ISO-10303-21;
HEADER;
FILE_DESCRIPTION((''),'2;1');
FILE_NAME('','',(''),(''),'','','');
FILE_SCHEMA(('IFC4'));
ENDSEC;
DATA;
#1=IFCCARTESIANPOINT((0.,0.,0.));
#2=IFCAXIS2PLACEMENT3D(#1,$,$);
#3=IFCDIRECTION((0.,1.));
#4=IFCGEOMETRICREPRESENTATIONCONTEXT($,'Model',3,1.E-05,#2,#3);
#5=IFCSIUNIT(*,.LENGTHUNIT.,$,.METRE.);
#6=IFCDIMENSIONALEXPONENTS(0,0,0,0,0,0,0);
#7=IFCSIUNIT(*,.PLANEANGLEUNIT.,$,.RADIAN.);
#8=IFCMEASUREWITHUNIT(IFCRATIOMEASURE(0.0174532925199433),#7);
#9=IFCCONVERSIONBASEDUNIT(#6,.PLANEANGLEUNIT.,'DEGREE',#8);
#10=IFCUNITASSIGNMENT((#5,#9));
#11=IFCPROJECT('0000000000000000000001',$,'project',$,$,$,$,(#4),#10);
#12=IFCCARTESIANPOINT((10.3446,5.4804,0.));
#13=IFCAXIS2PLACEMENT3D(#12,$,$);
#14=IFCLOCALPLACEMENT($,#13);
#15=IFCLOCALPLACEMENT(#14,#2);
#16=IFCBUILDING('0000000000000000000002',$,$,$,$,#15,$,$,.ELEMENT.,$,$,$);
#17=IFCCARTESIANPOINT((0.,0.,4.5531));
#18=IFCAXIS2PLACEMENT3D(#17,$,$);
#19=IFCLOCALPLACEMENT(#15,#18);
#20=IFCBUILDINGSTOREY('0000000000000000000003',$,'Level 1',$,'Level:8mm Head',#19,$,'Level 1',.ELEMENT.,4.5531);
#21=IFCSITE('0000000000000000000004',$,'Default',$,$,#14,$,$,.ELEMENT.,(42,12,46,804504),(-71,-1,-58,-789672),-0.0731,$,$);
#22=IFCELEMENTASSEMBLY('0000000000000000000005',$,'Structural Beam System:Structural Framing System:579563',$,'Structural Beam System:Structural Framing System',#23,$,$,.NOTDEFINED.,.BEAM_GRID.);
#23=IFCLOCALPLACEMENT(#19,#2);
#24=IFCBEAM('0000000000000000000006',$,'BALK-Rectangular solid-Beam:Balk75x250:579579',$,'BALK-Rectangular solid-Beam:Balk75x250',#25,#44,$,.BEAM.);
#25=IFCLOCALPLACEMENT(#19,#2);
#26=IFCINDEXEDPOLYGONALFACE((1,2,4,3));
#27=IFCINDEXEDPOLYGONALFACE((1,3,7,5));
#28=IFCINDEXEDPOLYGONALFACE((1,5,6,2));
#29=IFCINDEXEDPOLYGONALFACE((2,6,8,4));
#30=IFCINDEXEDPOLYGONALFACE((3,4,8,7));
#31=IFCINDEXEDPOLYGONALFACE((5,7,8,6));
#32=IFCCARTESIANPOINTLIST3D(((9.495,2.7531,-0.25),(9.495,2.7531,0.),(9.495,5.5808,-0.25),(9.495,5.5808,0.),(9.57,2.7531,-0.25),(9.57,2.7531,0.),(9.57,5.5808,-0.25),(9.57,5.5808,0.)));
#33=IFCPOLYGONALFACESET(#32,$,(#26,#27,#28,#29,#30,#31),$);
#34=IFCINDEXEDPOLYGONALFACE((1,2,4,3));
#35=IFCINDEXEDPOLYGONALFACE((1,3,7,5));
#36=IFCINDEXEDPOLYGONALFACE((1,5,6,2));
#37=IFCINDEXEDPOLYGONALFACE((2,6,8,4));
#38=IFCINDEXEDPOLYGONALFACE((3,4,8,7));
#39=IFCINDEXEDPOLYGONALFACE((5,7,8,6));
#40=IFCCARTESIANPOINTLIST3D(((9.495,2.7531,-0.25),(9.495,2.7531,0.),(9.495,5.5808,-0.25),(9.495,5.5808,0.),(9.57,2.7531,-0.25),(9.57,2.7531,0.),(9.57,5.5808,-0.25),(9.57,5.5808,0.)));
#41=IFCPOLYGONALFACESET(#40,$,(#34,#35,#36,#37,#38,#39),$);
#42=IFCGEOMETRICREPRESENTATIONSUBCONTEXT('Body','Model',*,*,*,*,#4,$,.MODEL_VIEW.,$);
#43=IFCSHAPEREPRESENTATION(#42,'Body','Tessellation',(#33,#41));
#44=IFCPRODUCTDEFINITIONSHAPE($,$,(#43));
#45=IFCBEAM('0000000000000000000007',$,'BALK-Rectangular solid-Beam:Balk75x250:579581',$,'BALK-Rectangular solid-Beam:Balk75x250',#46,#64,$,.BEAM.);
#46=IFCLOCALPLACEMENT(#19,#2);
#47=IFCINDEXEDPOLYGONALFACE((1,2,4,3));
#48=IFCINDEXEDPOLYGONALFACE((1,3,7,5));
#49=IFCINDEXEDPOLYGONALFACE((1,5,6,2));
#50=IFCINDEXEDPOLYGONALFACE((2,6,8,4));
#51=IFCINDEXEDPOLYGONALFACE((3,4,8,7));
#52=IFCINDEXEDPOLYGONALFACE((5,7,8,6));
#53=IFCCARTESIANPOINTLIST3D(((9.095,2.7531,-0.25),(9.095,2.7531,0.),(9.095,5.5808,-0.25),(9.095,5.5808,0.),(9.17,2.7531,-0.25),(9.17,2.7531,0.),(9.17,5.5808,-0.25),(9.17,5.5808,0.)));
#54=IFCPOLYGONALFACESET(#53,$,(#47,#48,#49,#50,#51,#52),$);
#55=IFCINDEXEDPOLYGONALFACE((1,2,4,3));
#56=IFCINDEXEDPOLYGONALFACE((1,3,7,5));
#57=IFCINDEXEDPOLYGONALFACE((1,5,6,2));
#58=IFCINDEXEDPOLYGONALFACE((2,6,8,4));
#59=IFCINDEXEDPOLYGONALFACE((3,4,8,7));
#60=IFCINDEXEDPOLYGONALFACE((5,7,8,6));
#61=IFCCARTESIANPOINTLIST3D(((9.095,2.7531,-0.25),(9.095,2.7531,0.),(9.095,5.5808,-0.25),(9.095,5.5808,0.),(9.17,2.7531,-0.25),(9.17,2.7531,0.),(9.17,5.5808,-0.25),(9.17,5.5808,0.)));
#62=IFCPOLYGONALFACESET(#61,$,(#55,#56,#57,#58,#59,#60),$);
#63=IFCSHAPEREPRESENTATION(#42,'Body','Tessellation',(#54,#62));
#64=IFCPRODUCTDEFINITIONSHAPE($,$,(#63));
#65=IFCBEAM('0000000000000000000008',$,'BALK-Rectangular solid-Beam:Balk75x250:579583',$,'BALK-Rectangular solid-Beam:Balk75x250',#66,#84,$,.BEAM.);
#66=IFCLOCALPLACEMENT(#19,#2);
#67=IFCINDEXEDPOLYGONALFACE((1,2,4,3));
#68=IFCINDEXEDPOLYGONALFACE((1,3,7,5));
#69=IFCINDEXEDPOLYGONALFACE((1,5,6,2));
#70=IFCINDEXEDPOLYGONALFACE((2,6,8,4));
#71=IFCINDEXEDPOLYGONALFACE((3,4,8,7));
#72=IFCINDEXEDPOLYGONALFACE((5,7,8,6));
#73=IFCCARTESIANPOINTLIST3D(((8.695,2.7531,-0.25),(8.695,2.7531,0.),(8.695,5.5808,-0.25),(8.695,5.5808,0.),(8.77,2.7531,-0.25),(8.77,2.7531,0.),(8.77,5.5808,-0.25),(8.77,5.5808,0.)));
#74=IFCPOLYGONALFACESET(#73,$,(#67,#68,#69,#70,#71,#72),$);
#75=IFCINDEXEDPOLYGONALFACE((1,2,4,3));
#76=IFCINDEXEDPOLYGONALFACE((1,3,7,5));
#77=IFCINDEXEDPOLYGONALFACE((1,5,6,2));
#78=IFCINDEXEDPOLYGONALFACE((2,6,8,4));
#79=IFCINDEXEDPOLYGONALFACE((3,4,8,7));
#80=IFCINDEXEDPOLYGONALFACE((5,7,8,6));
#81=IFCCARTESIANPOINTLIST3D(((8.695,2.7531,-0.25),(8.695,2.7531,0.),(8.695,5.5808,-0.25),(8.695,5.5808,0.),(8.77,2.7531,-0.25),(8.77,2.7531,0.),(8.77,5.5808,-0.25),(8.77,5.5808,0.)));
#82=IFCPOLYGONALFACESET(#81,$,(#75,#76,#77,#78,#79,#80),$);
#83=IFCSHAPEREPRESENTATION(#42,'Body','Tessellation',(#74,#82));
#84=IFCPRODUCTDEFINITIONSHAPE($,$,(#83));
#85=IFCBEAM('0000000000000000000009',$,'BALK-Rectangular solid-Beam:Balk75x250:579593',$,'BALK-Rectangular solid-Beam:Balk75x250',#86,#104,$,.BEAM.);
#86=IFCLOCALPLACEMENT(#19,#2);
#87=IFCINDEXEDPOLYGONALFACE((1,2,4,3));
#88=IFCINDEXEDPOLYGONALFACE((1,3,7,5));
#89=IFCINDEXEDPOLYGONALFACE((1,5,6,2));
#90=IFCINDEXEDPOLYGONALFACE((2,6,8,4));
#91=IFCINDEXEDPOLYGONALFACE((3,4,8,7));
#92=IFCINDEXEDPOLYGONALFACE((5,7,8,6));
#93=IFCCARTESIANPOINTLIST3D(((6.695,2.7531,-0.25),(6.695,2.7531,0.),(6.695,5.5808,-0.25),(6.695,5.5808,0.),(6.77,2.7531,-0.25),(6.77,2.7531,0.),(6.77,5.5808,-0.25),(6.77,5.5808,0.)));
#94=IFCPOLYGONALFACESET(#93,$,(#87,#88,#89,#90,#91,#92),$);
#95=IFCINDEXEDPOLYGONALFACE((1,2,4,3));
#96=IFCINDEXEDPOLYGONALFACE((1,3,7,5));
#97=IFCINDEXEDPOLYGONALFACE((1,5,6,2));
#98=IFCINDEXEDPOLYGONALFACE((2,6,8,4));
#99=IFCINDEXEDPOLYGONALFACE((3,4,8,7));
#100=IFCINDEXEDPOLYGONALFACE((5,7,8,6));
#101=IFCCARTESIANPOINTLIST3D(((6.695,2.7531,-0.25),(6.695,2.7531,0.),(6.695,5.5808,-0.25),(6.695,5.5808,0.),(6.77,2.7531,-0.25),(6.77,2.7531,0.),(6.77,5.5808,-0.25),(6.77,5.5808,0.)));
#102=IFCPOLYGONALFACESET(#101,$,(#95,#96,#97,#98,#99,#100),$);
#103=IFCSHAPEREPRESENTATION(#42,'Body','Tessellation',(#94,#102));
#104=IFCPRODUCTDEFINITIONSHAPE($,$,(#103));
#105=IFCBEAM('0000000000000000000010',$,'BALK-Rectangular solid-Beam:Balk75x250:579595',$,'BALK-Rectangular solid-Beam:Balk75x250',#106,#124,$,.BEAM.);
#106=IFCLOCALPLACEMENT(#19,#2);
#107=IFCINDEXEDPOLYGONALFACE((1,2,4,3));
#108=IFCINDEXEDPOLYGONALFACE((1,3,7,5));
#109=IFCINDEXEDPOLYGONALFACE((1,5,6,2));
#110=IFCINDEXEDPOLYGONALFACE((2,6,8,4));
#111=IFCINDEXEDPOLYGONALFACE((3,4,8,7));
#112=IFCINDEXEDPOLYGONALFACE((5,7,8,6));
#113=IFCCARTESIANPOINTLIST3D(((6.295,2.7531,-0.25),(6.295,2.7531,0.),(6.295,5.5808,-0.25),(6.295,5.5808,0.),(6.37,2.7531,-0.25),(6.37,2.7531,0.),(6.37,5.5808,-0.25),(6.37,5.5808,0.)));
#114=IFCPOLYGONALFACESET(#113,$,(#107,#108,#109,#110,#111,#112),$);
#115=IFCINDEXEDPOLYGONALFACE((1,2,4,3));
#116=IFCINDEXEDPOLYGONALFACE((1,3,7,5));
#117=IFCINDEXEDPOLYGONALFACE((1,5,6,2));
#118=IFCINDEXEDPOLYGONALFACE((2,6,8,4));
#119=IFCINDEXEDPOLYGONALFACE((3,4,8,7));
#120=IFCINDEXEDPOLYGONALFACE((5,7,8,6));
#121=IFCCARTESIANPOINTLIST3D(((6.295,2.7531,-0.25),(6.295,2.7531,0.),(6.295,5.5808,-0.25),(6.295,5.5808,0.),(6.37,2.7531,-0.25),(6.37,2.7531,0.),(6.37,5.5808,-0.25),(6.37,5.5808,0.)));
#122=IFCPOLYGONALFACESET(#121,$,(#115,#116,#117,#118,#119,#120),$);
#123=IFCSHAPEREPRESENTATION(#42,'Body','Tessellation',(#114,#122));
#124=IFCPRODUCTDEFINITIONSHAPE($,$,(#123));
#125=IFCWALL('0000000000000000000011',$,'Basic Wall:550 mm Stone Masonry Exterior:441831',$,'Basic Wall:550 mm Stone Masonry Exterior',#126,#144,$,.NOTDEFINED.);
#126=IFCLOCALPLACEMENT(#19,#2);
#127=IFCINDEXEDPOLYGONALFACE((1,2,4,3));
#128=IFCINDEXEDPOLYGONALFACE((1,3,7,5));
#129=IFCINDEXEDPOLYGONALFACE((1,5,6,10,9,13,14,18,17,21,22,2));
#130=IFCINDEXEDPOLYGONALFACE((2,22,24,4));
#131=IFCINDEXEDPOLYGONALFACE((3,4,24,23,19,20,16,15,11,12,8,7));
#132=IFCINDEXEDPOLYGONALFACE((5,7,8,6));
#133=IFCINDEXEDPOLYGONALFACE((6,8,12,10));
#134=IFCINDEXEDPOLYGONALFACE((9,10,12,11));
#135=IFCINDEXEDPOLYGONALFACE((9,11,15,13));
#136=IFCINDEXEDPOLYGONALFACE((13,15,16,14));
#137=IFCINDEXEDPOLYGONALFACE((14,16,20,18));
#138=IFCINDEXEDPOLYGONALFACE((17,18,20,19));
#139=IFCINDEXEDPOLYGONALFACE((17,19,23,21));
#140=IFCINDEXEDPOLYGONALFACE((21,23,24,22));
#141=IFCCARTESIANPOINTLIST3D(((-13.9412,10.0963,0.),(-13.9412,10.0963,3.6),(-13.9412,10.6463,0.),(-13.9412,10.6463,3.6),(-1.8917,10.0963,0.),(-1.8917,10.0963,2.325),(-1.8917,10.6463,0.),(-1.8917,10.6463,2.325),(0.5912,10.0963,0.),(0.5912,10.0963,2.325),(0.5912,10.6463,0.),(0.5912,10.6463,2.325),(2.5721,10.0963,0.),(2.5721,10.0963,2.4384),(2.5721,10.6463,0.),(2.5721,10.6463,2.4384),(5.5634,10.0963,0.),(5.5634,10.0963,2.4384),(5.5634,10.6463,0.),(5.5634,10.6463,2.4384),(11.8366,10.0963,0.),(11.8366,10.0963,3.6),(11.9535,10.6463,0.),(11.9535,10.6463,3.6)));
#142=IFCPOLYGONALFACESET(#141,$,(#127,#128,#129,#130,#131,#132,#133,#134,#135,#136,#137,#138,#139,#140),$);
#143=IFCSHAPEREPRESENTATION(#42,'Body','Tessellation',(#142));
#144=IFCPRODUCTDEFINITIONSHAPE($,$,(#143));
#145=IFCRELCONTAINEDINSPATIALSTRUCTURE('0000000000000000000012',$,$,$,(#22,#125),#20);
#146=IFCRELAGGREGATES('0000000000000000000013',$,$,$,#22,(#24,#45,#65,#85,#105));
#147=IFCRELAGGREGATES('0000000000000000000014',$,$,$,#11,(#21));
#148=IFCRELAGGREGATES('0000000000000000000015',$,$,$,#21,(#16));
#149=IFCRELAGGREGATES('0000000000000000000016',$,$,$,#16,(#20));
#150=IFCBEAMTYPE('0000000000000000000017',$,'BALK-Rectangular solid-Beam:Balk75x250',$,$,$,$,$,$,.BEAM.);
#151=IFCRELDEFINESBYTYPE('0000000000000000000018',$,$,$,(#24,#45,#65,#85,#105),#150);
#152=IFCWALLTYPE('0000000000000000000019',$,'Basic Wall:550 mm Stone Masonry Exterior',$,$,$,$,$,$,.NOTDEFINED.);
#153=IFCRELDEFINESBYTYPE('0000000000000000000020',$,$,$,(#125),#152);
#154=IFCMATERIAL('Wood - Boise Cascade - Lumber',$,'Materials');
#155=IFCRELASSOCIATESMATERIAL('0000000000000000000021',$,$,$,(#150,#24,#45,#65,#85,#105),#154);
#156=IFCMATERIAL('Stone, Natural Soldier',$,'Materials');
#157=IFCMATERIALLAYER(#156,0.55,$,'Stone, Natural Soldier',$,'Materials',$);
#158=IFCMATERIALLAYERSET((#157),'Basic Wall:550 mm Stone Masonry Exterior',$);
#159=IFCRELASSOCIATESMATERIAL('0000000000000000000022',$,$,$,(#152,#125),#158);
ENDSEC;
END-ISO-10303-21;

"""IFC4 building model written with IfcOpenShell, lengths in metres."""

from ifc_helpers import new_model, entity, si_unit, converted_unit, direction, frame, frame_2d, origin, origin_2d_with_axis, place, context, subcontext, project, spatial, polyline, rectangle, outline, extrude, source, transform, mapped, material, layer, layer_set, layer_usage, material_profile, profile_set, profile_usage, type_object, type_shapes, element, aggregate, save


model = new_model("IFC4")

# Units and contexts
model_context = context("Model", 3, precision=1e-05, world=origin(), true_north=direction((0.0, 1.0)))
body_context = subcontext(model_context, "Body", "Model", "MODEL_VIEW")
ifc_project = project(units=[si_unit("LENGTHUNIT", "METRE"), converted_unit("PLANEANGLEUNIT", "DEGREE", entity("IfcRatioMeasure", 0.0174532925199433), si_unit("PLANEANGLEUNIT", "RADIAN"), dimensions=[0, 0, 0, 0, 0, 0, 0])], contexts=[model_context])

# Site, building, storey
site_placement = place(None, frame((10.3446, 5.4804, 0.0)))
site = spatial("IfcSite", under=ifc_project, at=site_placement, Name="Default", CompositionType="ELEMENT", RefLatitude=(42, 12, 46, 804504), RefLongitude=(-71, -1, -58, -789672), RefElevation=-0.0731)
building_placement = place(site_placement, origin())
building = spatial("IfcBuilding", under=site, at=building_placement, CompositionType="ELEMENT")
storey_placement = place(building_placement, frame((0.0, 0.0, 4.5531)))
storey = spatial("IfcBuildingStorey", under=building, at=storey_placement, Name="Level 1", ObjectType="Level:8mm Head", LongName="Level 1", CompositionType="ELEMENT", Elevation=4.5531)

# Element assembly, beams
ifc_material_1 = material(Name="Wood - Boise Cascade - Lumber", Category="Materials")
ifc_material_profile = material_profile(ifc_material_1, rectangle(XDim=0.25, YDim=0.075, at=frame_2d((0.0, 0.0), x_axis=(1.0, 0.0))), Name="Balk75x250")
ifc_profile_set = profile_set([ifc_material_profile], Name="Balk75x250")
assembly_1_placement = place(storey_placement, origin())
assembly_1 = element("IfcElementAssembly", 1, at=assembly_1_placement, inside=storey, Name="Structural Beam System:Structural Framing System:579563", ObjectType="Structural Beam System:Structural Framing System", AssemblyPlace="NOTDEFINED", PredefinedType="BEAM_GRID")
ifc_profile_usage_1 = profile_usage(ifc_profile_set, cardinal=8)
beam_type_1 = type_object("IfcBeamType", Name="BALK-Rectangular solid-Beam:Balk75x250", PredefinedType="BEAM", material=ifc_profile_set)
shared_shape_1 = source(origin(), body_context, "Body", "SweptSolid", [
    extrude(rectangle(XDim=0.25, YDim=0.075, at=origin_2d_with_axis()), frame((-1.4138, 0.0, 0.0), z_axis=(1.0, 0.0, 0.0), x_axis=(0.0, 0.0, -1.0)), (0.0, 0.0, 1.0), 2.8276),
    extrude(rectangle(XDim=0.25, YDim=0.075, at=origin_2d_with_axis()), frame((-1.4138, 0.0, 0.0), z_axis=(1.0, 0.0, 0.0), x_axis=(0.0, 0.0, -1.0)), (0.0, 0.0, 1.0), 2.8276),
])
type_shapes(beam_type_1, [shared_shape_1])
beam_1_placement = place(assembly_1_placement, frame((9.5325, 4.167, -0.125), z_axis=(0.0, 0.0, 1.0), x_axis=(0.0, -1.0, 0.0)))
beam_1 = element("IfcBeam", 2, at=beam_1_placement, type_object=beam_type_1, material=ifc_profile_usage_1, Name="BALK-Rectangular solid-Beam:Balk75x250:579579", ObjectType="BALK-Rectangular solid-Beam:Balk75x250", PredefinedType="BEAM", context=body_context, shape_type="MappedRepresentation", body=[
    mapped(shared_shape_1, transform((0.0, 0.0, 0.0), scale=1.0)),
])
ifc_profile_usage_2 = profile_usage(ifc_profile_set, cardinal=8)
beam_2_placement = place(assembly_1_placement, frame((9.1325, 4.167, -0.125), z_axis=(0.0, 0.0, 1.0), x_axis=(0.0, -1.0, 0.0)))
beam_2 = element("IfcBeam", 3, at=beam_2_placement, type_object=beam_type_1, material=ifc_profile_usage_2, Name="BALK-Rectangular solid-Beam:Balk75x250:579581", ObjectType="BALK-Rectangular solid-Beam:Balk75x250", PredefinedType="BEAM", context=body_context, shape_type="MappedRepresentation", body=[
    mapped(shared_shape_1, transform((0.0, 0.0, 0.0), scale=1.0)),
])
ifc_profile_usage_3 = profile_usage(ifc_profile_set, cardinal=8)
beam_3_placement = place(assembly_1_placement, frame((8.7325, 4.167, -0.125), z_axis=(0.0, 0.0, 1.0), x_axis=(0.0, -1.0, 0.0)))
beam_3 = element("IfcBeam", 4, at=beam_3_placement, type_object=beam_type_1, material=ifc_profile_usage_3, Name="BALK-Rectangular solid-Beam:Balk75x250:579583", ObjectType="BALK-Rectangular solid-Beam:Balk75x250", PredefinedType="BEAM", context=body_context, shape_type="MappedRepresentation", body=[
    mapped(shared_shape_1, transform((0.0, 0.0, 0.0), scale=1.0)),
])
ifc_profile_usage_4 = profile_usage(ifc_profile_set, cardinal=8)
beam_4_placement = place(assembly_1_placement, frame((6.7325, 4.167, -0.125), z_axis=(0.0, 0.0, 1.0), x_axis=(0.0, -1.0, 0.0)))
beam_4 = element("IfcBeam", 5, at=beam_4_placement, type_object=beam_type_1, material=ifc_profile_usage_4, Name="BALK-Rectangular solid-Beam:Balk75x250:579593", ObjectType="BALK-Rectangular solid-Beam:Balk75x250", PredefinedType="BEAM", context=body_context, shape_type="MappedRepresentation", body=[
    mapped(shared_shape_1, transform((0.0, 0.0, 0.0), scale=1.0)),
])
ifc_profile_usage_5 = profile_usage(ifc_profile_set, cardinal=8)
beam_5_placement = place(assembly_1_placement, frame((6.3325, 4.167, -0.125), z_axis=(0.0, 0.0, 1.0), x_axis=(0.0, -1.0, 0.0)))
beam_5 = element("IfcBeam", 6, at=beam_5_placement, type_object=beam_type_1, material=ifc_profile_usage_5, Name="BALK-Rectangular solid-Beam:Balk75x250:579595", ObjectType="BALK-Rectangular solid-Beam:Balk75x250", PredefinedType="BEAM", context=body_context, shape_type="MappedRepresentation", body=[
    mapped(shared_shape_1, transform((0.0, 0.0, 0.0), scale=1.0)),
])
aggregate(assembly_1, [beam_1, beam_2, beam_3, beam_4, beam_5])

# Wall, openings
ifc_material_2 = material(Name="Stone, Natural Soldier", Category="Materials")
ifc_layer = layer(ifc_material_2, 0.55, Name="Stone, Natural Soldier", Category="Materials")
ifc_layer_set = layer_set([ifc_layer], Name="Basic Wall:550 mm Stone Masonry Exterior")
ifc_layer_usage = layer_usage(ifc_layer_set, "AXIS2", "NEGATIVE", 0.275)
wall_type = type_object("IfcWallType", Name="Basic Wall:550 mm Stone Masonry Exterior", PredefinedType="NOTDEFINED", material=ifc_layer_set)
wall_placement = place(storey_placement, frame((11.9535, 10.3713, 0.0), z_axis=(0.0, 0.0, 1.0), x_axis=(-1.0, 0.0, 0.0)))
wall = element("IfcWall", 7, at=wall_placement, inside=storey, type_object=wall_type, material=ifc_layer_usage, Name="Basic Wall:550 mm Stone Masonry Exterior:441831", ObjectType="Basic Wall:550 mm Stone Masonry Exterior", PredefinedType="NOTDEFINED", context=body_context, shape_type="SweptSolid", body=[
    extrude(outline(polyline([(0.0, -0.275), (25.8947, -0.275), (25.8947, 0.275), (25.3447, 0.275), (16.0836, 0.275), (15.5336, 0.275), (9.9349, 0.275), (9.3849, 0.275), (6.4526, 0.275), (6.3276, 0.275), (0.1169, 0.275), (0.0, -0.275)])), origin(), (0.0, 0.0, 1.0), 3.6),
])
opening_1_placement = place(wall_placement, frame((9.3814, 0.275, 0.0)))
element("IfcOpeningElement", 8, at=opening_1_placement, cuts=wall, ObjectType="Opening", PredefinedType="OPENING", context=body_context, shape_type="SweptSolid", body=[
    extrude(rectangle(XDim=2.4384, YDim=2.9912, at=frame_2d((0.0, 0.0), x_axis=(1.0, 0.0))), frame((-1.4956, -0.55, 1.2192), z_axis=(0.0, 1.0, 0.0), x_axis=(0.0, 0.0, -1.0)), (0.0, 0.0, 1.0), 0.55),
])
opening_2_placement = place(wall_placement, frame((13.8453, 0.275, 0.0)))
element("IfcOpeningElement", 9, at=opening_2_placement, cuts=wall, ObjectType="Opening", PredefinedType="OPENING", context=body_context, shape_type="SweptSolid", body=[
    extrude(rectangle(XDim=2.325, YDim=2.483, at=frame_2d((0.0, 0.0), x_axis=(1.0, 0.0))), frame((-1.2415, -0.55, 1.1625), z_axis=(0.0, 1.0, 0.0), x_axis=(0.0, 0.0, -1.0)), (0.0, 0.0, 1.0), 0.55),
])

save(model, "model.ifc")
